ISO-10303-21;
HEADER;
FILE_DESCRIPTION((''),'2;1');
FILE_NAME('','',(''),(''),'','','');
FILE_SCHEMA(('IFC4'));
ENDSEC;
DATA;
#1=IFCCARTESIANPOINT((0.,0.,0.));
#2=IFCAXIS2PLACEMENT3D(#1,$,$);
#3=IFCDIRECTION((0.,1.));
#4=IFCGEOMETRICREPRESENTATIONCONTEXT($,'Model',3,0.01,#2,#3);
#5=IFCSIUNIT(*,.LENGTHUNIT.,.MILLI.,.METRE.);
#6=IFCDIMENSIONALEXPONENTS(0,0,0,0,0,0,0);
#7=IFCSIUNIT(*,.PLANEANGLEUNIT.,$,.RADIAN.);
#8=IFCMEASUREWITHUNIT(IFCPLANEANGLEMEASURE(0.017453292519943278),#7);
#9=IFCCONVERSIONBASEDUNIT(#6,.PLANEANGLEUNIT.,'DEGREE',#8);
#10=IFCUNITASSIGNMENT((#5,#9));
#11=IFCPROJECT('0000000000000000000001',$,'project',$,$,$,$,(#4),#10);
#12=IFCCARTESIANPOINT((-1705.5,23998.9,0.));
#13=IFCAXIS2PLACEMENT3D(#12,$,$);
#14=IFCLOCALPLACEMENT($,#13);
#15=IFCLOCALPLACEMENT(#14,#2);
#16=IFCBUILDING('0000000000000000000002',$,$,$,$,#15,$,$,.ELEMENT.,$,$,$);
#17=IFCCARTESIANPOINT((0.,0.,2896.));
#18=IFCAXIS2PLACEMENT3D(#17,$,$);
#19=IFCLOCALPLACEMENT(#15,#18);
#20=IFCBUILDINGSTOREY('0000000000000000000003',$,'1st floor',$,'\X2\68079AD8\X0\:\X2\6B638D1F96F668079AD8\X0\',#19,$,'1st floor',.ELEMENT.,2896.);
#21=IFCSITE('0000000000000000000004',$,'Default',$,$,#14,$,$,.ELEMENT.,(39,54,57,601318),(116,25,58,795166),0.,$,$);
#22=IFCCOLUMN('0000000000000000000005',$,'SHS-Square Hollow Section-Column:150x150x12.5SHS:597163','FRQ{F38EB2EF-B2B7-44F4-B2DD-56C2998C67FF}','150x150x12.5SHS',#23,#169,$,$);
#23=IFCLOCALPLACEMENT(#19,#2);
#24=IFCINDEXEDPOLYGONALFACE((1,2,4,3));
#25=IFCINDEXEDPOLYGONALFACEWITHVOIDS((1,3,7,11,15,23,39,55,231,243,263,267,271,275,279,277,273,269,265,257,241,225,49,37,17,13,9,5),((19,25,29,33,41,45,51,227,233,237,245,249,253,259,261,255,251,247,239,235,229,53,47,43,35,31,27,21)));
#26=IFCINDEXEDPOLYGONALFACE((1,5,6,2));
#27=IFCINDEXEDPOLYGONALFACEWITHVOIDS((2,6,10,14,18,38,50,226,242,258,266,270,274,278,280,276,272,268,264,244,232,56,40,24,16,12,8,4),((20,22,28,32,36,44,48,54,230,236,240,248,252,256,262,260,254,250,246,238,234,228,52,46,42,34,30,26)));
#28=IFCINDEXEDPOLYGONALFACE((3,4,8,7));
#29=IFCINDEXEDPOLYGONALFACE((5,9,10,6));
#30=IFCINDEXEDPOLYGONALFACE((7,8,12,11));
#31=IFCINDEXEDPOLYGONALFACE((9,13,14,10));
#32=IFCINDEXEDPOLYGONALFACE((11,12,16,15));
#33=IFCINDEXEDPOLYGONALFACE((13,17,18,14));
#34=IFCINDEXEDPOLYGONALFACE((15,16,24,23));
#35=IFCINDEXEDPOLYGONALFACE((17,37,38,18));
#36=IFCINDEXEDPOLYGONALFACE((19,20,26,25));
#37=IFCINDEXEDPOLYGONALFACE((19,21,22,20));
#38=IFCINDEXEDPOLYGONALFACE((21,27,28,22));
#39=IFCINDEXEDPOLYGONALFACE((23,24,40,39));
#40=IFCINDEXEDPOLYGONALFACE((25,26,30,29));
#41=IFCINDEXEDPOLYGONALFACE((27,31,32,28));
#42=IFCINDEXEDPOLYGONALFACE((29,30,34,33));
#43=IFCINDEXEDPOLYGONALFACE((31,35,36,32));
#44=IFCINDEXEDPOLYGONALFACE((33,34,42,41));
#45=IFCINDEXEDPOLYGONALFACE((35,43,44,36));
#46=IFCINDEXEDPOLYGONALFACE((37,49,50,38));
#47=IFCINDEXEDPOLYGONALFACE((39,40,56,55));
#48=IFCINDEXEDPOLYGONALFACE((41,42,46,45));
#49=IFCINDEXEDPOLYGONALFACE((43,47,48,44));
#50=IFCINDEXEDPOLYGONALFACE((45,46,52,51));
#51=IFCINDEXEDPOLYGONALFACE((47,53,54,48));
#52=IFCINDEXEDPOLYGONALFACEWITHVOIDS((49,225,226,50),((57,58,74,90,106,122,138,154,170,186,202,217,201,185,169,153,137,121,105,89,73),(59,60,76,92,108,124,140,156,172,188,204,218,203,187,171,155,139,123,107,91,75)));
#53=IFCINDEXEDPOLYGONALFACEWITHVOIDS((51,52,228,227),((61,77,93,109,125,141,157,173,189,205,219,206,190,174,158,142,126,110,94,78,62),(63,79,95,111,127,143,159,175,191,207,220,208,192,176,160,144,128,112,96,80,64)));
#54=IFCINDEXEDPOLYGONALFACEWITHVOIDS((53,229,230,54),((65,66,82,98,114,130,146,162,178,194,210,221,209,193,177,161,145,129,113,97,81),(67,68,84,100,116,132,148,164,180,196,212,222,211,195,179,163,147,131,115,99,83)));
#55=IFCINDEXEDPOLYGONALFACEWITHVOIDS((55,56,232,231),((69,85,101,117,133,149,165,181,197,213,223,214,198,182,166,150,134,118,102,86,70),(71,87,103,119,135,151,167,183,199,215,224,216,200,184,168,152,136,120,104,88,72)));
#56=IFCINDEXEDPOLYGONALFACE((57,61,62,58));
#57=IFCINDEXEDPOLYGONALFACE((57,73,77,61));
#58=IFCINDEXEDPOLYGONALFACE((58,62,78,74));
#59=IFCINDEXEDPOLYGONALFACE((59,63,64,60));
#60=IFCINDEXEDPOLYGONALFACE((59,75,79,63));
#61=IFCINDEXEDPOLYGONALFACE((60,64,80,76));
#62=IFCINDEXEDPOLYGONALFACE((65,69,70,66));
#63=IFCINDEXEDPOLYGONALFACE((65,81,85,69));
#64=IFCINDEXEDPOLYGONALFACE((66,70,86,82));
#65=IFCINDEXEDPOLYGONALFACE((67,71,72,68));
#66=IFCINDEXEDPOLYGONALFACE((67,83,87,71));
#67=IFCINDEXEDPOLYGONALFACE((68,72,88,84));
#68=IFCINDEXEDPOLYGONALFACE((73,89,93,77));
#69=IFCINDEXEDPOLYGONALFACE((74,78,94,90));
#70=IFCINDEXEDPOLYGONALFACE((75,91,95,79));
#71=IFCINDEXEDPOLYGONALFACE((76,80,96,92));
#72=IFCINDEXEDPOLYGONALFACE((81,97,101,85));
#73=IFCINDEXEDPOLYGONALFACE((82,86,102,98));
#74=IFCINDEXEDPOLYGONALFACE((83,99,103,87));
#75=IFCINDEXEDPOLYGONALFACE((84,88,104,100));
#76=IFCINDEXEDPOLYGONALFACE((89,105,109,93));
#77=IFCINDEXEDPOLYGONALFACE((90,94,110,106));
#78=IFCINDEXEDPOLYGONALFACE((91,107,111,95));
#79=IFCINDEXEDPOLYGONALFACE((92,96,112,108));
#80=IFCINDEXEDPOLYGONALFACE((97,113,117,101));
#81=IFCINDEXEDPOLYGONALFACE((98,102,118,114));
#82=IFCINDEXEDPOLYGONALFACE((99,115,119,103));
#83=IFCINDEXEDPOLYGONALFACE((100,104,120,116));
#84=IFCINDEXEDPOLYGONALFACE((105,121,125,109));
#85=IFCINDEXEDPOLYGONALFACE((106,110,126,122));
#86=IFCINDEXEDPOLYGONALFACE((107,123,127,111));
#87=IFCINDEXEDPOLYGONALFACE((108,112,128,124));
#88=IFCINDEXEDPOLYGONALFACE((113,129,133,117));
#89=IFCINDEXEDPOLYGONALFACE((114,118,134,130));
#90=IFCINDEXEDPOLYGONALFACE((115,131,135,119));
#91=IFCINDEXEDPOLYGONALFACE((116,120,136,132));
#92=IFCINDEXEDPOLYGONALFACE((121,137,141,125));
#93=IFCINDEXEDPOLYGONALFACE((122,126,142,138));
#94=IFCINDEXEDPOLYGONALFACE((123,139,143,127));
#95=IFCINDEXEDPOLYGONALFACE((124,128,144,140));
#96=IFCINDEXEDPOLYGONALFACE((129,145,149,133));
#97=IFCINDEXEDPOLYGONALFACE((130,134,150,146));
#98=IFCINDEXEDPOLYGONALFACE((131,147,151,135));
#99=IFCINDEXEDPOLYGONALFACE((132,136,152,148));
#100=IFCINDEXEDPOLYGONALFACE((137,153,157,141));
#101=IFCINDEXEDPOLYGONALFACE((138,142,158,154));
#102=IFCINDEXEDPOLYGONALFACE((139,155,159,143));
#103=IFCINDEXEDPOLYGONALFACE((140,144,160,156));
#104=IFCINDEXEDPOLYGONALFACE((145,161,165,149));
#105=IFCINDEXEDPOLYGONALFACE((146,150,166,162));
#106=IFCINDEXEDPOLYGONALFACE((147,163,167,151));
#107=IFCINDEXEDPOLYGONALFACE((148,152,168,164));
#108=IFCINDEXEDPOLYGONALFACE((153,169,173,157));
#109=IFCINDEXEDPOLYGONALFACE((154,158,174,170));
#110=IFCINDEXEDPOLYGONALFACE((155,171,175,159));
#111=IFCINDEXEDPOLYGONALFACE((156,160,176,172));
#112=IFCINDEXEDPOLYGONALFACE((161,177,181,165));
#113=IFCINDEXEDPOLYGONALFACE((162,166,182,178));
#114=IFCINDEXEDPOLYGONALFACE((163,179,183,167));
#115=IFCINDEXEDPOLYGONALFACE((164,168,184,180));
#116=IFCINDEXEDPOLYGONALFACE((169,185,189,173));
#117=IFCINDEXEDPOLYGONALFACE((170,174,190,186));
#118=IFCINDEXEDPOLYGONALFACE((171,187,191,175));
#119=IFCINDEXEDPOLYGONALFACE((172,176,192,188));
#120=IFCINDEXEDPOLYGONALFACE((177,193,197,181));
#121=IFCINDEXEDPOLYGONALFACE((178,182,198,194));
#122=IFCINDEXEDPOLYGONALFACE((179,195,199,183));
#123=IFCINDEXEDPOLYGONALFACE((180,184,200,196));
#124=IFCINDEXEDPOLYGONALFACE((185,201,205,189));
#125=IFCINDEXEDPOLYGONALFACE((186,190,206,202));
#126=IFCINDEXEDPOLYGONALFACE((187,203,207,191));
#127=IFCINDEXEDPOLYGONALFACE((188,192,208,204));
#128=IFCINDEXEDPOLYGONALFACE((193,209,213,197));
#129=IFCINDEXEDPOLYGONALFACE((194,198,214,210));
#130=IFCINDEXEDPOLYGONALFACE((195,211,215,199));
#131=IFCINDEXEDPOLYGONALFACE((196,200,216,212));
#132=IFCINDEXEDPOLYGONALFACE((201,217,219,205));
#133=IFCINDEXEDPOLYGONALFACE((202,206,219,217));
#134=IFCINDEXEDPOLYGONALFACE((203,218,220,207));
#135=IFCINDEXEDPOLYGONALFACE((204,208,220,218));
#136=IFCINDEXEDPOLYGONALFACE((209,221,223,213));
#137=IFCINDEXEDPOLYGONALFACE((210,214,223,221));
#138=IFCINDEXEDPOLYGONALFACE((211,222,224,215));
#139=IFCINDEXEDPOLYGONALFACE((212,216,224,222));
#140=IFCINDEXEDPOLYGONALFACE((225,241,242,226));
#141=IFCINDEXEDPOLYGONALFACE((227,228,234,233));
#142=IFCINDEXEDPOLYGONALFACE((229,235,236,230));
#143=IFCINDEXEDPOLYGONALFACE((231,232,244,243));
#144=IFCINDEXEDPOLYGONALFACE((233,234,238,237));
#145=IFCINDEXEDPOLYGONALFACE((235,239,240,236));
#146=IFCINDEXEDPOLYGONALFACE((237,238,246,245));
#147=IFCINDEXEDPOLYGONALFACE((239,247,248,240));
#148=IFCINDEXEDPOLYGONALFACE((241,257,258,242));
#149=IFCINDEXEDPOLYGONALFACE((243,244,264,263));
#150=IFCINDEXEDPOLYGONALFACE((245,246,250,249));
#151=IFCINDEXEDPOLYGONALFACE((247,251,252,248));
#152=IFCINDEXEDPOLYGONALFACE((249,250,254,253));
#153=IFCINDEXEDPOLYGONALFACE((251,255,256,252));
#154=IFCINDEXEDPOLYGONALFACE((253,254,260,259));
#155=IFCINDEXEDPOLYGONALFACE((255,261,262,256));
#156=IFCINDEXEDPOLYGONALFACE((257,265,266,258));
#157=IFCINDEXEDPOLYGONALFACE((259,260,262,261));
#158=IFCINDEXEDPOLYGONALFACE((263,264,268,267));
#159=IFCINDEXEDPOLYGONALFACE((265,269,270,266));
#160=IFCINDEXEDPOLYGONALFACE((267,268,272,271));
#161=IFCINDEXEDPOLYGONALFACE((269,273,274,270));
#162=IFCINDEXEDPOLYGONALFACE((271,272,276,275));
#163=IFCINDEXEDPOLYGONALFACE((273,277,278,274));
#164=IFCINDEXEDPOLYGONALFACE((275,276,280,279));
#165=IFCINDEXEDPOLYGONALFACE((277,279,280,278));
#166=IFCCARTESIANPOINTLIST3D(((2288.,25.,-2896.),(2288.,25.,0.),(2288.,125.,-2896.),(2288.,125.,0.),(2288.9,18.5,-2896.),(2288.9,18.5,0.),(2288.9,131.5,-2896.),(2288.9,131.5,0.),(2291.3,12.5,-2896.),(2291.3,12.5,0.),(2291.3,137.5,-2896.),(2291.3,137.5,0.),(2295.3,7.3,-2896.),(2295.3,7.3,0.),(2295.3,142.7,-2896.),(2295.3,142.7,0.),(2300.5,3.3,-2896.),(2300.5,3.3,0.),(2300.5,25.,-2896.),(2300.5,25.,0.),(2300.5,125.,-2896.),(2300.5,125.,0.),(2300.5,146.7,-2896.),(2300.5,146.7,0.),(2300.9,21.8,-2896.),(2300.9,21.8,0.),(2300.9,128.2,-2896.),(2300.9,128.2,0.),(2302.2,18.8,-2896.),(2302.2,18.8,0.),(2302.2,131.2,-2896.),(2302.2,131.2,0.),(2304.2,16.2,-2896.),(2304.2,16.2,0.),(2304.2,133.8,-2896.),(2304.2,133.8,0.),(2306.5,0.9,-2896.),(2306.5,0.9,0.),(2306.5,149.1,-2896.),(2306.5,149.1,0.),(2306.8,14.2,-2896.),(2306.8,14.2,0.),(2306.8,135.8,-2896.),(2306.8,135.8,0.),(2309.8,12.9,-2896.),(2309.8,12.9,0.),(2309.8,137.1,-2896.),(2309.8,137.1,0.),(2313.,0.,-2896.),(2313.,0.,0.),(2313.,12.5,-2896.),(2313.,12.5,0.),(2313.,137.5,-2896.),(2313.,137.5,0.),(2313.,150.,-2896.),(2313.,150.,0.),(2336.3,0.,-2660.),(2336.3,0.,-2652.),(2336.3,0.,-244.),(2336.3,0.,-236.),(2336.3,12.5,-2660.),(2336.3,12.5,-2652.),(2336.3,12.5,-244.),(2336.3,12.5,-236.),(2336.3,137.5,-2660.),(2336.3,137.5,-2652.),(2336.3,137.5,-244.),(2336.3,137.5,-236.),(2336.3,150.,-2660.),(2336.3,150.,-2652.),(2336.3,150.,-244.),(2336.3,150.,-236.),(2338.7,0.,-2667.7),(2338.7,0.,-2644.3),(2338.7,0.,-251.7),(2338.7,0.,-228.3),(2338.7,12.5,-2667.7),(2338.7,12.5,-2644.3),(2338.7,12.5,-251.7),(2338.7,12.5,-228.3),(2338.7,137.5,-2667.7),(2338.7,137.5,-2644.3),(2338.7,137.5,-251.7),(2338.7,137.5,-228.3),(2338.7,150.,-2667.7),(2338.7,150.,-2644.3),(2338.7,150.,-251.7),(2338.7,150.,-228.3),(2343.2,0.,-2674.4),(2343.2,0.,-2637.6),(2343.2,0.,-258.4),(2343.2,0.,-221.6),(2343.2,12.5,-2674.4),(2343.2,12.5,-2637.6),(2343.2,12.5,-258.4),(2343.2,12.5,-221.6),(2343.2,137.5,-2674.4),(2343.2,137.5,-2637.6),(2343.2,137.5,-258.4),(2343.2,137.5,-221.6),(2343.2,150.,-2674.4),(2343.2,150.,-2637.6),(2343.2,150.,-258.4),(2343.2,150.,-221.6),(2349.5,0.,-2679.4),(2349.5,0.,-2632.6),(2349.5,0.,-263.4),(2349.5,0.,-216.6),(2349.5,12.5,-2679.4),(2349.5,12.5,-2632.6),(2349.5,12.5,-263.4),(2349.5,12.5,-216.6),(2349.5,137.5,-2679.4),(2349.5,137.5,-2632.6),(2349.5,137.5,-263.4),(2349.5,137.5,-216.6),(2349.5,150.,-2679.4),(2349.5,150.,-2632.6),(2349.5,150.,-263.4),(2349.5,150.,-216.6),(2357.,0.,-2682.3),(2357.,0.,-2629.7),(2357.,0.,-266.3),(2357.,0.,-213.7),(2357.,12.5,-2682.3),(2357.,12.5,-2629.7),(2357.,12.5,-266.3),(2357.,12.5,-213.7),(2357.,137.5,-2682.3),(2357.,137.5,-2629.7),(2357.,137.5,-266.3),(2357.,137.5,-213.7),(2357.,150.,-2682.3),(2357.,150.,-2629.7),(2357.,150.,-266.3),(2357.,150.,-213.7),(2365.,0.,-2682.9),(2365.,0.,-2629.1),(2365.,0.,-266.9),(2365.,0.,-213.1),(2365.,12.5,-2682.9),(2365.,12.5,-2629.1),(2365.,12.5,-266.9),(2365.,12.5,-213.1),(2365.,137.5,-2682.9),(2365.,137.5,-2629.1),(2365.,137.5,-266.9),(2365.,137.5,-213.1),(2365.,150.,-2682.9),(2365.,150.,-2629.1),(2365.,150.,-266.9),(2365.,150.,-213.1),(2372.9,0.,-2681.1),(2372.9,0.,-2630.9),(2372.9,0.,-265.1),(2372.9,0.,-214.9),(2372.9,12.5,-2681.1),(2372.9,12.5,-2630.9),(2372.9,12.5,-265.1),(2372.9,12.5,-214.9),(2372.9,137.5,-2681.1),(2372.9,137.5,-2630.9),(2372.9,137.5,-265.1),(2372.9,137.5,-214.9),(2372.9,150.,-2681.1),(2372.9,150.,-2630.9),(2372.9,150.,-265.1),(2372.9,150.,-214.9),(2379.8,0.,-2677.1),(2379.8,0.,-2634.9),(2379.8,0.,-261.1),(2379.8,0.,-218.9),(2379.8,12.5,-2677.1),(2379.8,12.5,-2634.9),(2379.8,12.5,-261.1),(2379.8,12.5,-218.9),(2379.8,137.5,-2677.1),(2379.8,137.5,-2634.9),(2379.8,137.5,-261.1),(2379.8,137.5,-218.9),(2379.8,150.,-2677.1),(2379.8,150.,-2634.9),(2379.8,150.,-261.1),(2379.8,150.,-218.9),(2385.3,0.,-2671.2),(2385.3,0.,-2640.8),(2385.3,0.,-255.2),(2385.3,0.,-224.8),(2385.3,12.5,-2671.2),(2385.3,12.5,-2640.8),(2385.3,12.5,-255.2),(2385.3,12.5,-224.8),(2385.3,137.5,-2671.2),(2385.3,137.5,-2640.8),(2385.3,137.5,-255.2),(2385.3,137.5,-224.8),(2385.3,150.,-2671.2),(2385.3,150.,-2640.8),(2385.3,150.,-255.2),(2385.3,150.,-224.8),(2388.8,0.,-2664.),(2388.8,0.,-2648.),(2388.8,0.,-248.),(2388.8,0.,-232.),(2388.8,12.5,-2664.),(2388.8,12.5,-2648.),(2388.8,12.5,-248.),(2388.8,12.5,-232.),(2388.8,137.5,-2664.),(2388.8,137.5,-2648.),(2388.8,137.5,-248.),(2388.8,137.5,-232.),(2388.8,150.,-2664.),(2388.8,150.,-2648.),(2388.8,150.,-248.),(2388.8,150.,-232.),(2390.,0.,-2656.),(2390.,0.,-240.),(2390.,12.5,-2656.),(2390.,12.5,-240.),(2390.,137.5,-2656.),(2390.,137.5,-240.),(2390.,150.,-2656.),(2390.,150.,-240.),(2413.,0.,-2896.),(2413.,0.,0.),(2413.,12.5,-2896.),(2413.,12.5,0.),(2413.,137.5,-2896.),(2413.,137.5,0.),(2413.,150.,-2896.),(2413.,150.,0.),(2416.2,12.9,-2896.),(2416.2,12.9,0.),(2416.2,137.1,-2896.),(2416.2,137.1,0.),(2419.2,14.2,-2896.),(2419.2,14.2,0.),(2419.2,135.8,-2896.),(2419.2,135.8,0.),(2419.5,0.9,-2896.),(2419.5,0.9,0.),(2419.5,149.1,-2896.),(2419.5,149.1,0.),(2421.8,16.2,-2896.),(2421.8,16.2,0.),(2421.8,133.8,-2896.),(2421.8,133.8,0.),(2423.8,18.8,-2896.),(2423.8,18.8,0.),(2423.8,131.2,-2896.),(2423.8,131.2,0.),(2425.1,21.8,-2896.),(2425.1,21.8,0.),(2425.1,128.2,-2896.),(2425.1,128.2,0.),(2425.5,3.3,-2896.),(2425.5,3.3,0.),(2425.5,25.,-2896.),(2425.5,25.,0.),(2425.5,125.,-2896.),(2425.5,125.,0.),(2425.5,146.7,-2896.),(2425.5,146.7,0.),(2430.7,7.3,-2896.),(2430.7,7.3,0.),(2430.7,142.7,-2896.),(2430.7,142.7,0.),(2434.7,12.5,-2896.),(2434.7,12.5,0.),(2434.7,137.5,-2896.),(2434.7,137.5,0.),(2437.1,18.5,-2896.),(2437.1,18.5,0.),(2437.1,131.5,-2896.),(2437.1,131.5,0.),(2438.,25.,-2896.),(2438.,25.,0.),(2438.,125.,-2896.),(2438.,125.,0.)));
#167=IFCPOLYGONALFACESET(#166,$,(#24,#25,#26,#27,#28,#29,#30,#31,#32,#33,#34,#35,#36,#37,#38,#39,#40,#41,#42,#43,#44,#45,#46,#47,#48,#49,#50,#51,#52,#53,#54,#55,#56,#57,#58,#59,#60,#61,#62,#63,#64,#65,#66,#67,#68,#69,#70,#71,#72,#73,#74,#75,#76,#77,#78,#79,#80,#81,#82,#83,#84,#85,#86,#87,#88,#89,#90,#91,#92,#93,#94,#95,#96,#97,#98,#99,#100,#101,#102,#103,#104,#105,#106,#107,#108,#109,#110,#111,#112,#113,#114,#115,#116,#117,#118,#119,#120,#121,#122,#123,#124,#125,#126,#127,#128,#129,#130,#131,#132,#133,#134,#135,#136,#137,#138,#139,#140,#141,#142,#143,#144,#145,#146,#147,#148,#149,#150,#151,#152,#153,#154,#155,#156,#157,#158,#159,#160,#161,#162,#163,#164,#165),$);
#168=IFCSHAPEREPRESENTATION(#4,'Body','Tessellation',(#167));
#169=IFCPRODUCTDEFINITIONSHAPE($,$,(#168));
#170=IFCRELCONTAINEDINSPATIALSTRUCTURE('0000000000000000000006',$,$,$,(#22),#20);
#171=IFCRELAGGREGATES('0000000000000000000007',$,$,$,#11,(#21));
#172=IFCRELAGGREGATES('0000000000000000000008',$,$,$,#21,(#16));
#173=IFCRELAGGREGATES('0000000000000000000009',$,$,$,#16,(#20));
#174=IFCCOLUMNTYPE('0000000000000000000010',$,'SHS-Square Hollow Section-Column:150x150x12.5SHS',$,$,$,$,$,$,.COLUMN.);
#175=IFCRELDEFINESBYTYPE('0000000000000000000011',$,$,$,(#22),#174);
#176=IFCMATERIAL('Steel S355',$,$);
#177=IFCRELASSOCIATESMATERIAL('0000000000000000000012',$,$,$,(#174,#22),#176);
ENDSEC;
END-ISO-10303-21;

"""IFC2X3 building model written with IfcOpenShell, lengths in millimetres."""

from ifc_helpers import new_model, entity, si_unit, converted_unit, direction, frame, frame_2d, origin, origin_2d, place, context, project, spatial, circle_curve, hollow_rectangle, outline, extrude, material, type_object, element, save


model = new_model("IFC2X3")

# Units and contexts
model_context = context("Model", 3, precision=0.01, world=origin(), true_north=direction((0.0, 1.0)))
ifc_project = project(units=[si_unit("LENGTHUNIT", "METRE", prefix="MILLI"), converted_unit("PLANEANGLEUNIT", "DEGREE", entity("IfcPlaneAngleMeasure", 0.017453292519943278), si_unit("PLANEANGLEUNIT", "RADIAN"), dimensions=[0, 0, 0, 0, 0, 0, 0])], contexts=[model_context])

# Site, building, storey
site_placement = place(None, frame((-1705.5, 23998.9, 0.0)))
site = spatial("IfcSite", under=ifc_project, at=site_placement, Name="Default", CompositionType="ELEMENT", RefLatitude=(39, 54, 57, 601318), RefLongitude=(116, 25, 58, 795166), RefElevation=0.0)
building_placement = place(site_placement, origin())
building = spatial("IfcBuilding", under=site, at=building_placement, CompositionType="ELEMENT")
storey_placement = place(building_placement, frame((0.0, 0.0, 2896.0)))
storey = spatial("IfcBuildingStorey", under=building, at=storey_placement, Name="1st floor", ObjectType="标高:正负零标高", LongName="1st floor", CompositionType="ELEMENT", Elevation=2896.0)

# Shared definitions
ifc_material_1 = material(Name="Steel S355")

# Column, openings
column_type_1 = type_object("IfcColumnType", Name="SHS-Square Hollow Section-Column:150x150x12.5SHS", PredefinedType="COLUMN", material=ifc_material_1)
column_1_placement = place(storey_placement, frame((2363.0, 75.0, 0.0), z_axis=(0.0, 0.0, 1.0), x_axis=(0.0, -1.0, 0.0)))
column_1 = element("IfcColumn", 1, at=column_1_placement, inside=storey, type_object=column_type_1, material=ifc_material_1, Name="SHS-Square Hollow Section-Column:150x150x12.5SHS:597163", Description="FRQ{F38EB2EF-B2B7-44F4-B2DD-56C2998C67FF}", ObjectType="150x150x12.5SHS", context=model_context, shape_type="SweptSolid", body=[
    extrude(hollow_rectangle(XDim=150.0, YDim=150.0, WallThickness=12.5, InnerFilletRadius=12.5, OuterFilletRadius=25.0, at=origin_2d()), origin(), (0.0, 0.0, -1.0), 2896.0),
])
opening_1_placement = place(column_1_placement, frame((-175.1, 0.0, 0.0), z_axis=(1.0, 0.0, 0.0), x_axis=(0.0, 1.0, 0.0)))
element("IfcOpeningElement", 2, at=opening_1_placement, cuts=column_1, ObjectType="Opening", context=model_context, shape_type="SweptSolid", body=[
    extrude(outline(circle_curve(frame_2d((0.0, -240.0), x_axis=(1.0, 0.0)), 27.0)), origin(), (0.0, 0.0, 1.0), 350.2),
])
opening_2_placement = place(column_1_placement, frame((-175.1, 0.0, -2896.0), z_axis=(1.0, 0.0, 0.0), x_axis=(0.0, 1.0, 0.0)))
element("IfcOpeningElement", 3, at=opening_2_placement, cuts=column_1, ObjectType="Opening", context=model_context, shape_type="SweptSolid", body=[
    extrude(outline(circle_curve(frame_2d((0.0, 240.0), x_axis=(1.0, 0.0)), 27.0)), origin(), (0.0, 0.0, 1.0), 350.2),
])

save(model, "model.ifc")
